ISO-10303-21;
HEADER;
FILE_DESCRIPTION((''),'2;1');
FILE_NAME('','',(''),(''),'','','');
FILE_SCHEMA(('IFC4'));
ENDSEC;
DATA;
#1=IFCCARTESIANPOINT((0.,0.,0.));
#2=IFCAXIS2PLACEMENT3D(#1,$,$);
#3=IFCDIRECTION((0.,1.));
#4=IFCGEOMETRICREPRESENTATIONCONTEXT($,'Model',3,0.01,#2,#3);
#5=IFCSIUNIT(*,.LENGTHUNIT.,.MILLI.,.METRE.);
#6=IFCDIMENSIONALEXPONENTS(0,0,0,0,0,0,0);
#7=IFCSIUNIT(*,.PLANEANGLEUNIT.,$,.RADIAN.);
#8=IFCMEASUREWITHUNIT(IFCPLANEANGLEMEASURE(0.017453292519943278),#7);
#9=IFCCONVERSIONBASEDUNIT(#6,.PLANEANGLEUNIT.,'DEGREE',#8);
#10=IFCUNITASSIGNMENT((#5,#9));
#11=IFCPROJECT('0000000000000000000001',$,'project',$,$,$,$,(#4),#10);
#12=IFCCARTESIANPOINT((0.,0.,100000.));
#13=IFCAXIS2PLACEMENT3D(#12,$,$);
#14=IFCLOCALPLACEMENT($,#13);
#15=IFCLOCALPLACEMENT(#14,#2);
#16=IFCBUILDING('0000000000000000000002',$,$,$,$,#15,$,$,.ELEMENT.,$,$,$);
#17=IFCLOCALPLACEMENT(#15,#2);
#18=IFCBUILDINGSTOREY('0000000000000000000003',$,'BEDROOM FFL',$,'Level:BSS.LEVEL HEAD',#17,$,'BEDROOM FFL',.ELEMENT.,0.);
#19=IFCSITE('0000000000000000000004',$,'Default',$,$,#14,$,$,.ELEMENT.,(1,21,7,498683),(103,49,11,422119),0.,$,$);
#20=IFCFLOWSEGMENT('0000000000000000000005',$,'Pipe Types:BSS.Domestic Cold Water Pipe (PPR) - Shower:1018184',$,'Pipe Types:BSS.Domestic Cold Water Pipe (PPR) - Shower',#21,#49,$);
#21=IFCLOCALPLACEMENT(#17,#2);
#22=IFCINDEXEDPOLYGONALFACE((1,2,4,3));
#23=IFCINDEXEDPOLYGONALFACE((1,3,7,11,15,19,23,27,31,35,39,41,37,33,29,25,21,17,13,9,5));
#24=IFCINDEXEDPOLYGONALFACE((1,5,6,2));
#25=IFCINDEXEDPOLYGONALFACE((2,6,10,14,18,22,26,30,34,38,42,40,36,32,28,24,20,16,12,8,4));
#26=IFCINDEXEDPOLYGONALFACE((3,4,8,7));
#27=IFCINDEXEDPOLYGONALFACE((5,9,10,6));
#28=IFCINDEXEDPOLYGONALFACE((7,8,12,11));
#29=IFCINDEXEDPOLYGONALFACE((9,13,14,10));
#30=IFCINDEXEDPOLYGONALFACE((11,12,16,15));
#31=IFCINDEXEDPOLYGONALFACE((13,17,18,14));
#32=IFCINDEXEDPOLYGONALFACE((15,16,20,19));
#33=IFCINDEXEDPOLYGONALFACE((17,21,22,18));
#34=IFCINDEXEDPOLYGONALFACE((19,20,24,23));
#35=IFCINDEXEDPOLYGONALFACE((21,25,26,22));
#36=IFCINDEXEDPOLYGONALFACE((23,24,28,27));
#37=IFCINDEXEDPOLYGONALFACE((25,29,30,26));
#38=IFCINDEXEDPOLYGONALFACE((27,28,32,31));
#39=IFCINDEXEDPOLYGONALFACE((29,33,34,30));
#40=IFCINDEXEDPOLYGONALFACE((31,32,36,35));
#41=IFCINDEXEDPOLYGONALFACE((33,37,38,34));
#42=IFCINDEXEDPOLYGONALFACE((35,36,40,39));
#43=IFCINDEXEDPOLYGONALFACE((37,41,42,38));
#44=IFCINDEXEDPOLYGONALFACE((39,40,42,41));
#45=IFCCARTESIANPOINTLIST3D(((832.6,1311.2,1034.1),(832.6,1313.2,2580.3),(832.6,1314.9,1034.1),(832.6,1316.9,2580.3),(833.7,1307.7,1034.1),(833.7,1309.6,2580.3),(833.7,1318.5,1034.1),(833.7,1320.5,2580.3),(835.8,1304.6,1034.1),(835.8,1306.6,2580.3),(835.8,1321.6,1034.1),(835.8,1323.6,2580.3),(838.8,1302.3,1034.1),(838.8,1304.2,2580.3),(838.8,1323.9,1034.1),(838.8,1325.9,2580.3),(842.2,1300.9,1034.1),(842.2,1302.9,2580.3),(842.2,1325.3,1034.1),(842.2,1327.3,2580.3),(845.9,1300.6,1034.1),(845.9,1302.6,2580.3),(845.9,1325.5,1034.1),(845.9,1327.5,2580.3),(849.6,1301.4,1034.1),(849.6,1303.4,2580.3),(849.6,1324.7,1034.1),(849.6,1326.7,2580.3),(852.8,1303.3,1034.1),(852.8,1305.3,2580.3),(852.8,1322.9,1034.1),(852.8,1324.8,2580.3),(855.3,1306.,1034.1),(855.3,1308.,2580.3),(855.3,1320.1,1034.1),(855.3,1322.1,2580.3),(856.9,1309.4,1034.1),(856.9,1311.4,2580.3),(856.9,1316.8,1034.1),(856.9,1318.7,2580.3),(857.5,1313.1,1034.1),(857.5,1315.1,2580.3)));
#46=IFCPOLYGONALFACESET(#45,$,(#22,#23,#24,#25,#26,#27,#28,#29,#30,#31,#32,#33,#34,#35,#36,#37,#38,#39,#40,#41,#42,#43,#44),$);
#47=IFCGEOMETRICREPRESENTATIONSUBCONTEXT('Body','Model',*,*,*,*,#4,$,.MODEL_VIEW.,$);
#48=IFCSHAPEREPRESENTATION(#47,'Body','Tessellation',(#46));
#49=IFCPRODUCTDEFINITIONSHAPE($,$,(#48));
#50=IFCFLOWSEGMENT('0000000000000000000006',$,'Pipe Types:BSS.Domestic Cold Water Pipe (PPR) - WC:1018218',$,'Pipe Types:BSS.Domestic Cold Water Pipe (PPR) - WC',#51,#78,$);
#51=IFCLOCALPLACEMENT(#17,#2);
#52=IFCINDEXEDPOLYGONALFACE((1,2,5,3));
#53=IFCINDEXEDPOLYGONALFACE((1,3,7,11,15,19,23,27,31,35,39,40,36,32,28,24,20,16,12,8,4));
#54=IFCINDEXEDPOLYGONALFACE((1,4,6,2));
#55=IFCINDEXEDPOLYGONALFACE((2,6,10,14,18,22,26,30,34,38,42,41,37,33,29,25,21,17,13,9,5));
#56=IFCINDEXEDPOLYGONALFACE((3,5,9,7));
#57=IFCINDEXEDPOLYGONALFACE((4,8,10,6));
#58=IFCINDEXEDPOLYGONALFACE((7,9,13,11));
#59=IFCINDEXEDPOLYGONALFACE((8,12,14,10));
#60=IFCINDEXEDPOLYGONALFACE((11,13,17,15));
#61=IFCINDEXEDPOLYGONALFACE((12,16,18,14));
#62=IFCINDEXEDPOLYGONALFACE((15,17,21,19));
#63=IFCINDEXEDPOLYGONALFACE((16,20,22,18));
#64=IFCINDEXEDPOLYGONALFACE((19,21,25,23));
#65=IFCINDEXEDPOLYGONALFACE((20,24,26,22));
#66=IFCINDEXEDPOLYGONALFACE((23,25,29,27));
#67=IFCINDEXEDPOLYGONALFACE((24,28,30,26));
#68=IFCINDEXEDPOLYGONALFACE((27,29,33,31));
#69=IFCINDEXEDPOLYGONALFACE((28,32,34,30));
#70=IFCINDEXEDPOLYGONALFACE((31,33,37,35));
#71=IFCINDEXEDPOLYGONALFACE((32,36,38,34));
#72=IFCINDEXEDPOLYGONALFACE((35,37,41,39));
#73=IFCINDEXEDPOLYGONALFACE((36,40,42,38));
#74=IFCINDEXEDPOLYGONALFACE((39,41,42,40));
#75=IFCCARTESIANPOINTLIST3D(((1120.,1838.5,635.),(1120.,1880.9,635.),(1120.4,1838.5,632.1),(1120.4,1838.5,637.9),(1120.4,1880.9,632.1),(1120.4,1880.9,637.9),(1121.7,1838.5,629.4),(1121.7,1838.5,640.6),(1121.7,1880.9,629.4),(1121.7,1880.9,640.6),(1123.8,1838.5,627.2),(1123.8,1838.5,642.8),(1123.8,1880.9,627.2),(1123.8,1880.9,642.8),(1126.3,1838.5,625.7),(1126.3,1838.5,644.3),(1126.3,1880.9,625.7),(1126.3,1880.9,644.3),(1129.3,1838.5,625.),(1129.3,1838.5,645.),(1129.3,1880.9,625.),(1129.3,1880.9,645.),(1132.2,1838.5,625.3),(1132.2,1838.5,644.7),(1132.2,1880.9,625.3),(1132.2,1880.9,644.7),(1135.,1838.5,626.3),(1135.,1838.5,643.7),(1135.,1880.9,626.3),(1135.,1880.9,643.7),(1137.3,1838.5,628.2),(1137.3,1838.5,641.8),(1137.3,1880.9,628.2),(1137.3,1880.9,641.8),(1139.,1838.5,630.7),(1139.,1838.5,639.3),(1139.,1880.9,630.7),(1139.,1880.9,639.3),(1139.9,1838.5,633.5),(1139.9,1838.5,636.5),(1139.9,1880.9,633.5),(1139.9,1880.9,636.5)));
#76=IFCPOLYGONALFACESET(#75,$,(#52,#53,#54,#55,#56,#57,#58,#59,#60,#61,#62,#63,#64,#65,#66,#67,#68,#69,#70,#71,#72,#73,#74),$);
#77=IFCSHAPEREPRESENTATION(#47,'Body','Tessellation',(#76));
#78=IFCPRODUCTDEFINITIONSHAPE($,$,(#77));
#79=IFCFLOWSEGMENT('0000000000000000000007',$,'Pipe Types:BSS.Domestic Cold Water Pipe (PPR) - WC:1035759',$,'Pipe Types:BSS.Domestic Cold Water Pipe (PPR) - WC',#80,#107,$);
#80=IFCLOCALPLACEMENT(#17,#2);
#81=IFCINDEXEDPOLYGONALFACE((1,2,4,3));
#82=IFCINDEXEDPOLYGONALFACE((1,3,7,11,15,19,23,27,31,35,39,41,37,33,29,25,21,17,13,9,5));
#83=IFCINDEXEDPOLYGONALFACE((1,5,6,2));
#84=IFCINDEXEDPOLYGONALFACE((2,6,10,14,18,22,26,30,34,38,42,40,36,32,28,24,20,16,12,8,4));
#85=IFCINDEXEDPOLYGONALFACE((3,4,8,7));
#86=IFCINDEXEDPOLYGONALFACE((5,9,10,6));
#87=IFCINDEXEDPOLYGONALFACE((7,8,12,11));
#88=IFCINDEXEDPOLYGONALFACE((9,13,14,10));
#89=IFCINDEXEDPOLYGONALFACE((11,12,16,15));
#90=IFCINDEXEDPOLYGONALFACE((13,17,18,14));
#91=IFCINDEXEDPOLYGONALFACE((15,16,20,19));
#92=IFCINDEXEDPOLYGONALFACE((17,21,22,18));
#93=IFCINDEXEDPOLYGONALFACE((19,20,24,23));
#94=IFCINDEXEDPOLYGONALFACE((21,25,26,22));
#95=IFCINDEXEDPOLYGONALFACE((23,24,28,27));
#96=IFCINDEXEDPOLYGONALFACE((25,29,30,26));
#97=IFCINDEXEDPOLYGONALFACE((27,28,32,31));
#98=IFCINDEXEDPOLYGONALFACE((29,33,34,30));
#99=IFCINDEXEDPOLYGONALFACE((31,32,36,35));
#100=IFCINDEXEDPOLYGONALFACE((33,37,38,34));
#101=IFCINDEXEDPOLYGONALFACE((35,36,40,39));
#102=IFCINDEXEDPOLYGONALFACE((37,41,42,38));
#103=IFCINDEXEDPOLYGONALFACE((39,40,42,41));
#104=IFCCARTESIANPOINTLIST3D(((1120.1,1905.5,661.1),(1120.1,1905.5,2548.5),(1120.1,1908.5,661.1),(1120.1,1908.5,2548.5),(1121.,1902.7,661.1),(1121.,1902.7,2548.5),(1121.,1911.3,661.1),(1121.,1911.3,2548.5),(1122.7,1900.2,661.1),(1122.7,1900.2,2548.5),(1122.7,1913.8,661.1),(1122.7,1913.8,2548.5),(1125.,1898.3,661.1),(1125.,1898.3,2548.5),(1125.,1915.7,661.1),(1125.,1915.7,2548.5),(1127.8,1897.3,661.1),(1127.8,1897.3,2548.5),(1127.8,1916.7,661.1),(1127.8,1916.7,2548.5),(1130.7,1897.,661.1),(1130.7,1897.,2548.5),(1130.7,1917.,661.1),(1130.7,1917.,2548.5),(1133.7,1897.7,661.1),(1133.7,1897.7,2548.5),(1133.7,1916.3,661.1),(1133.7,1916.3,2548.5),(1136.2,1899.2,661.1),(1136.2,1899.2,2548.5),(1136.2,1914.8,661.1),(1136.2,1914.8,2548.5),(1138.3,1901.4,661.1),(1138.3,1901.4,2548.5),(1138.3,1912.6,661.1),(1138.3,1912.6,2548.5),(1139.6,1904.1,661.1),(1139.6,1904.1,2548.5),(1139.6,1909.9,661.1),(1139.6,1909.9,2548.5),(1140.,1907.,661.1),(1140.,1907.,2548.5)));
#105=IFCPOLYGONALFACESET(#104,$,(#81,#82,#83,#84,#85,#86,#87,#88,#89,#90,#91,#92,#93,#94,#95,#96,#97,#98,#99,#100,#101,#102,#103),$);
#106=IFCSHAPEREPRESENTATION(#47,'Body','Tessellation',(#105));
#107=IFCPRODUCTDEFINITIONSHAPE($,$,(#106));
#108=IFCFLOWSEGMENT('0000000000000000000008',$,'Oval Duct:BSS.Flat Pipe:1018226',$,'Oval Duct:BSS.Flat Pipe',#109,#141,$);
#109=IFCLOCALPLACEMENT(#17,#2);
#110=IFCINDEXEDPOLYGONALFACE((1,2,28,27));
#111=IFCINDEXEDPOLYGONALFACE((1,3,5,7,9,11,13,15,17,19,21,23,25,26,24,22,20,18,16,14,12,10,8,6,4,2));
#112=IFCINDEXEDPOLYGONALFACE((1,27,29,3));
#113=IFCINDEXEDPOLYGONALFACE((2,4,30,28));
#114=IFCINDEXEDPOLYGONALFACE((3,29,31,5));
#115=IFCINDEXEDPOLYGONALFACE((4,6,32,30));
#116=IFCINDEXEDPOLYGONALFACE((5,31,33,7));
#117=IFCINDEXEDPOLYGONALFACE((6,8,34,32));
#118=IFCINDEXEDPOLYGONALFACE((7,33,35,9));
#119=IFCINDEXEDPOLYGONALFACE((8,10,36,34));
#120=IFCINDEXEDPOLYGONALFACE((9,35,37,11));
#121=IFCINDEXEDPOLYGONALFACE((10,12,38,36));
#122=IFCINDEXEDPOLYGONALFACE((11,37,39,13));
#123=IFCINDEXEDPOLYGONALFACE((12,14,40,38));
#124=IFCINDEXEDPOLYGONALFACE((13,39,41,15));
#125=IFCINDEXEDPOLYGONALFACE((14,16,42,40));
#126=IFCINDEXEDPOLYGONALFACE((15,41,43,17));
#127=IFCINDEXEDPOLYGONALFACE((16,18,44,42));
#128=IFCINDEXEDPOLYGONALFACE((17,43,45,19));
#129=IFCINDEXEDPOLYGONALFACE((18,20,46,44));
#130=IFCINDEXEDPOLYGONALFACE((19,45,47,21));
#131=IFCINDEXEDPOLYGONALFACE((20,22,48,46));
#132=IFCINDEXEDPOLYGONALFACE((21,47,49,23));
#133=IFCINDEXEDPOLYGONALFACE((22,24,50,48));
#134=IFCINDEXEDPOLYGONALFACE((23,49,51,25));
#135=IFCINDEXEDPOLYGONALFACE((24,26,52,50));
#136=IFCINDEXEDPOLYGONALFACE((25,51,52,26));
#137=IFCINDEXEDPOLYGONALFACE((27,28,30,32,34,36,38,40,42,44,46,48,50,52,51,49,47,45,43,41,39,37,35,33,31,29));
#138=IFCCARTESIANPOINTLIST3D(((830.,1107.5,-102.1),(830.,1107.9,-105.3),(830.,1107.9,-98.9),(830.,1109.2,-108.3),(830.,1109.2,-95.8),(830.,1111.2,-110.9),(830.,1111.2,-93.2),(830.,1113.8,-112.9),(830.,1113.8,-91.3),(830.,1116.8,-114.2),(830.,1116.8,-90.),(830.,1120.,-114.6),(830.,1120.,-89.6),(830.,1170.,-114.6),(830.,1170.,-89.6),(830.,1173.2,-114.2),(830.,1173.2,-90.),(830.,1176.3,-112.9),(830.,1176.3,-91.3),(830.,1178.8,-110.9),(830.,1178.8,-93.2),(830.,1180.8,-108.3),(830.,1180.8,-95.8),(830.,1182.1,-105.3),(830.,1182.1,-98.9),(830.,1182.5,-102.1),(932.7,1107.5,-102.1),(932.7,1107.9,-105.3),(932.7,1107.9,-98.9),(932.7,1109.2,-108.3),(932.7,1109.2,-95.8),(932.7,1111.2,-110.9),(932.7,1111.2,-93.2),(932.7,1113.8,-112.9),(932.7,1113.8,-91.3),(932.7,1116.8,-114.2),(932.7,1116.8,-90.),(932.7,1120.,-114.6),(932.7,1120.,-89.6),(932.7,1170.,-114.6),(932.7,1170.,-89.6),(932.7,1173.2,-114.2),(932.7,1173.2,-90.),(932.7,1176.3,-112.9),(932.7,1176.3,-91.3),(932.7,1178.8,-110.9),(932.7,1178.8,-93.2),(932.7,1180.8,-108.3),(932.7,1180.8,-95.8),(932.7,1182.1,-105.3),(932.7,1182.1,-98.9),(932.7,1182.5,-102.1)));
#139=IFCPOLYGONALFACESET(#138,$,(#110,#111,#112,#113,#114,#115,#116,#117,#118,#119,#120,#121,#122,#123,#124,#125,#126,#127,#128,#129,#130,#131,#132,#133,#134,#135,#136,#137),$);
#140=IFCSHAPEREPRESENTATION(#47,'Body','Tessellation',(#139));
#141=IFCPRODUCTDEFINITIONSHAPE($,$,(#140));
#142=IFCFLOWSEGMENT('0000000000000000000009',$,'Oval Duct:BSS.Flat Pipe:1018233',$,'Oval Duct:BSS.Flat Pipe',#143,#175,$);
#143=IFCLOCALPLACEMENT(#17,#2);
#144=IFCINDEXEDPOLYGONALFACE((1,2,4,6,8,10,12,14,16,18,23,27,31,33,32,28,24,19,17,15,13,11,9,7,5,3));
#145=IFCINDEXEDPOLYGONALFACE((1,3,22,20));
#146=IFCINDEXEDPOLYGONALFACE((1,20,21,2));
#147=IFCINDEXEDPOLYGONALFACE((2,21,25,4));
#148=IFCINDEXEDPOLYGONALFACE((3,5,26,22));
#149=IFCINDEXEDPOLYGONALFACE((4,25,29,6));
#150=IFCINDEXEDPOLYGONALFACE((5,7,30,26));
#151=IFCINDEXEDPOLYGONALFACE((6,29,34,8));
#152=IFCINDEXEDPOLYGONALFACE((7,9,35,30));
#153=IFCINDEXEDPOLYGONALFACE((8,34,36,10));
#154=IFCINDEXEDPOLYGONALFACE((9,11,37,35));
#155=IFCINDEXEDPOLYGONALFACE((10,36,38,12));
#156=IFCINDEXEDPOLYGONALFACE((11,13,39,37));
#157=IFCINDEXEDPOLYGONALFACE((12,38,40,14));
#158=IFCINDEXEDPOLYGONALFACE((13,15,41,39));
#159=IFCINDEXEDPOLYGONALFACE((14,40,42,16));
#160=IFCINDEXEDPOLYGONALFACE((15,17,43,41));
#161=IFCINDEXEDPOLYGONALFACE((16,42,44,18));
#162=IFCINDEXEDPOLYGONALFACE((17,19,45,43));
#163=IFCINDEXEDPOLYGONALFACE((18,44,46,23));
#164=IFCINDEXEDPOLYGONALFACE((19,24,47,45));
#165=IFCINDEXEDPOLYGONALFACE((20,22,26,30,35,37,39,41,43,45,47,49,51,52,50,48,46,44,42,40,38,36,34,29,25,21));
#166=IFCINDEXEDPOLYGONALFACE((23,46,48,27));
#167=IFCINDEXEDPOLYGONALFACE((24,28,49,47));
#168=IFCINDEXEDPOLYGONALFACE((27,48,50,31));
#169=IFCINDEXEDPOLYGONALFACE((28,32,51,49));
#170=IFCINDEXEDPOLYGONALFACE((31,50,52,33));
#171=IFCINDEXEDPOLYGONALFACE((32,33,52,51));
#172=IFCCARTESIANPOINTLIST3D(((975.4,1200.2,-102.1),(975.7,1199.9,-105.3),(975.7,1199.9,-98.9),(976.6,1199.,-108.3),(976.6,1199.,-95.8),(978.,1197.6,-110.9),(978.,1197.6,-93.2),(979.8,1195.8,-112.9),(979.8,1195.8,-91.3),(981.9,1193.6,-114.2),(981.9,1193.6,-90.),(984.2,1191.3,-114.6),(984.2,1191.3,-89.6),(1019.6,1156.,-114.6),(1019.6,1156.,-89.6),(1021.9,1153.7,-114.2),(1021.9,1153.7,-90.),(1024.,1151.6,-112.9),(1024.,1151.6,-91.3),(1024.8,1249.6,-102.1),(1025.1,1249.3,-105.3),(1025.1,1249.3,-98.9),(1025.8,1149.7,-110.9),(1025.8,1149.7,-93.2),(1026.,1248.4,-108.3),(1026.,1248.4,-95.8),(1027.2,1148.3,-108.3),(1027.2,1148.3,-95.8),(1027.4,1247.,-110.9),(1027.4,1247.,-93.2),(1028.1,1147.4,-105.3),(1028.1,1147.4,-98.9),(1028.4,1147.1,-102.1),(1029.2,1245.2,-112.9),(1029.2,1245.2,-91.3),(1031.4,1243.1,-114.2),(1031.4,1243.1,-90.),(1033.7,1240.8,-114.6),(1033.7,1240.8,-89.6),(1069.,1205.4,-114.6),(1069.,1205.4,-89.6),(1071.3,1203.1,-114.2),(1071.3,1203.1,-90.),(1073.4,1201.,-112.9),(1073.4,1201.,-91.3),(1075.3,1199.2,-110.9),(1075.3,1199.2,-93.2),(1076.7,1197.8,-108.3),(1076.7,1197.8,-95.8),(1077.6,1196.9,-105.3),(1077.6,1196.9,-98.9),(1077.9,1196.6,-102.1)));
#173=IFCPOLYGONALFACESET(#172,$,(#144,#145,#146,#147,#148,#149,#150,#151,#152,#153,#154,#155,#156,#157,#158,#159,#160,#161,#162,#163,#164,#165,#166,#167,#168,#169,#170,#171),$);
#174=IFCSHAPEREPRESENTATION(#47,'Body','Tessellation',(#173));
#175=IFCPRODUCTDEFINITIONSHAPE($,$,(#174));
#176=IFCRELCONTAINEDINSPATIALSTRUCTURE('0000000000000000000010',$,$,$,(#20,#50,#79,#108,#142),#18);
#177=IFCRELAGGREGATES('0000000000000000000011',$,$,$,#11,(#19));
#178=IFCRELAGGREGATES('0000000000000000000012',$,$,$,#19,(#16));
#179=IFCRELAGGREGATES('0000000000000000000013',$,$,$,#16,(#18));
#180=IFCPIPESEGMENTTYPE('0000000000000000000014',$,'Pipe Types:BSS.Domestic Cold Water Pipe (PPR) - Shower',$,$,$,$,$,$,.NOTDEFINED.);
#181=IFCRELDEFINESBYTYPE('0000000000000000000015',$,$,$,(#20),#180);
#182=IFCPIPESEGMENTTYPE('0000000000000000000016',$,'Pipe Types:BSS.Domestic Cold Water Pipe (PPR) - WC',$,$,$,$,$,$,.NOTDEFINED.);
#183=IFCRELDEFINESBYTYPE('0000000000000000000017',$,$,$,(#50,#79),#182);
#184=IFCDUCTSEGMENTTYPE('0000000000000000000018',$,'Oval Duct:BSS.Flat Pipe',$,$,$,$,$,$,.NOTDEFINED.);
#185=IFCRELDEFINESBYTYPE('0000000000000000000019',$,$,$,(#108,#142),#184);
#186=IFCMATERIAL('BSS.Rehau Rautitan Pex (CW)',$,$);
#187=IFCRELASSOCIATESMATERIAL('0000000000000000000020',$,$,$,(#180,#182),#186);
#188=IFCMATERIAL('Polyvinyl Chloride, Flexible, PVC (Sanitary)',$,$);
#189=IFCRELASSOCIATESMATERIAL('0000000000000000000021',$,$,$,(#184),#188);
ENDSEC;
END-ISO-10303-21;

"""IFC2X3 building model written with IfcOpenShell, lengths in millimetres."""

from ifc_helpers import new_model, entity, si_unit, converted_unit, direction, frame, frame_2d, origin, origin_2d_with_axis, place, context, subcontext, project, spatial, polyline, circle_curve, parameter, trimmed, segment, composite_curve, circle, outline, extrude, material, type_object, element, save


model = new_model("IFC2X3")

# Units and contexts
model_context = context("Model", 3, precision=0.01, world=origin(), true_north=direction((0.0, 1.0)))
body_context = subcontext(model_context, "Body", "Model", "MODEL_VIEW")
ifc_project = project(units=[si_unit("LENGTHUNIT", "METRE", prefix="MILLI"), converted_unit("PLANEANGLEUNIT", "DEGREE", entity("IfcPlaneAngleMeasure", 0.017453292519943278), si_unit("PLANEANGLEUNIT", "RADIAN"), dimensions=[0, 0, 0, 0, 0, 0, 0])], contexts=[model_context])

# Site, building, storey
site_placement = place(None, frame((0.0, 0.0, 100000.0)))
site = spatial("IfcSite", under=ifc_project, at=site_placement, Name="Default", CompositionType="ELEMENT", RefLatitude=(1, 21, 7, 498683), RefLongitude=(103, 49, 11, 422119), RefElevation=0.0)
building_placement = place(site_placement, origin())
building = spatial("IfcBuilding", under=site, at=building_placement, CompositionType="ELEMENT")
storey_placement = place(building_placement, origin())
storey = spatial("IfcBuildingStorey", under=building, at=storey_placement, Name="BEDROOM FFL", ObjectType="Level:BSS.LEVEL HEAD", LongName="BEDROOM FFL", CompositionType="ELEMENT", Elevation=0.0)

# Flow segments
ifc_material_1 = material(Name="Polyvinyl Chloride, Flexible, PVC (Sanitary)")
ifc_material_2 = material(Name="BSS.Rehau Rautitan Pex (CW)")
pipe_segment_type_1 = type_object("IfcPipeSegmentType", Name="Pipe Types:BSS.Domestic Cold Water Pipe (PPR) - Shower", PredefinedType="NOTDEFINED", material=ifc_material_2)
flow_segment_1_placement = place(storey_placement, origin())
element("IfcFlowSegment", 1, at=flow_segment_1_placement, inside=storey, type_object=pipe_segment_type_1, Name="Pipe Types:BSS.Domestic Cold Water Pipe (PPR) - Shower:1018184", ObjectType="Pipe Types:BSS.Domestic Cold Water Pipe (PPR) - Shower", context=body_context, shape_type="SweptSolid", body=[
    extrude(circle(Radius=12.5, at=frame_2d((0.0, 0.0), x_axis=(1.0, 0.0))), frame((845.0, 1313.1, 1034.1), z_axis=(0.000001, 0.001284, 0.999999), x_axis=(1.0, 0.0, -0.000001)), (0.0, 0.0, 1.0), 1546.2),
])
pipe_segment_type_2 = type_object("IfcPipeSegmentType", Name="Pipe Types:BSS.Domestic Cold Water Pipe (PPR) - WC", PredefinedType="NOTDEFINED", material=ifc_material_2)
flow_segment_2_placement = place(storey_placement, origin())
element("IfcFlowSegment", 2, at=flow_segment_2_placement, inside=storey, type_object=pipe_segment_type_2, Name="Pipe Types:BSS.Domestic Cold Water Pipe (PPR) - WC:1018218", ObjectType="Pipe Types:BSS.Domestic Cold Water Pipe (PPR) - WC", context=body_context, shape_type="SweptSolid", body=[
    extrude(circle(Radius=10.0, at=origin_2d_with_axis()), frame((1130.0, 1838.5, 635.0), z_axis=(0.0, 1.0, 0.0), x_axis=(-1.0, 0.0, 0.0)), (0.0, 0.0, 1.0), 42.4),
])
flow_segment_3_placement = place(storey_placement, origin())
element("IfcFlowSegment", 3, at=flow_segment_3_placement, inside=storey, type_object=pipe_segment_type_2, Name="Pipe Types:BSS.Domestic Cold Water Pipe (PPR) - WC:1035759", ObjectType="Pipe Types:BSS.Domestic Cold Water Pipe (PPR) - WC", context=body_context, shape_type="SweptSolid", body=[
    extrude(circle(Radius=10.0, at=frame_2d((0.0, 0.0), x_axis=(1.0, 0.0))), frame((1130.0, 1907.0, 661.1)), (0.0, 0.0, 1.0), 1887.4),
])
duct_segment_type = type_object("IfcDuctSegmentType", Name="Oval Duct:BSS.Flat Pipe", PredefinedType="NOTDEFINED", material=ifc_material_1)
flow_segment_4_placement = place(storey_placement, origin())
element("IfcFlowSegment", 4, at=flow_segment_4_placement, inside=storey, type_object=duct_segment_type, Name="Oval Duct:BSS.Flat Pipe:1018226", ObjectType="Oval Duct:BSS.Flat Pipe", context=body_context, shape_type="SweptSolid", body=[
    extrude(outline(composite_curve([segment(polyline([(-25.0, -12.5), (25.0, -12.5)]), True, "CONTINUOUS"), segment(trimmed(circle_curve(frame_2d((25.0, 0.0), x_axis=(-1.0, 0.0)), 12.5), [parameter(90.0)], [parameter(180.0)], True, "PARAMETER"), True, "CONTINUOUS"), segment(trimmed(circle_curve(frame_2d((25.0, 0.0), x_axis=(-1.0, 0.0)), 12.5), [parameter(180.0)], [parameter(270.0)], True, "PARAMETER"), True, "CONTINUOUS"), segment(polyline([(25.0, 12.5), (-25.0, 12.5)]), True, "CONTINUOUS"), segment(trimmed(circle_curve(frame_2d((-25.0, 0.0), x_axis=(-1.0, 0.0)), 12.5), [parameter(270.0)], [parameter(0.0)], True, "PARAMETER"), True, "CONTINUOUS"), segment(trimmed(circle_curve(frame_2d((-25.0, 0.0), x_axis=(-1.0, 0.0)), 12.5), [parameter(0.0)], [parameter(90.0)], True, "PARAMETER"), True, "CONTINUOUS")], self_intersect=False)), frame((830.0, 1145.0, -102.1), z_axis=(1.0, 0.0, 0.0), x_axis=(0.0, -1.0, 0.0)), (0.0, 0.0, 1.0), 102.7),
])
flow_segment_5_placement = place(storey_placement, origin())
element("IfcFlowSegment", 5, at=flow_segment_5_placement, inside=storey, type_object=duct_segment_type, Name="Oval Duct:BSS.Flat Pipe:1018233", ObjectType="Oval Duct:BSS.Flat Pipe", context=body_context, shape_type="SweptSolid", body=[
    extrude(outline(composite_curve([segment(polyline([(-25.0, -12.5), (25.0, -12.5)]), True, "CONTINUOUS"), segment(trimmed(circle_curve(frame_2d((25.0, 0.0), x_axis=(-1.0, 0.0)), 12.5), [parameter(90.0)], [parameter(180.0)], True, "PARAMETER"), True, "CONTINUOUS"), segment(trimmed(circle_curve(frame_2d((25.0, 0.0), x_axis=(-1.0, 0.0)), 12.5), [parameter(180.0)], [parameter(270.0)], True, "PARAMETER"), True, "CONTINUOUS"), segment(polyline([(25.0, 12.5), (-25.0, 12.5)]), True, "CONTINUOUS"), segment(trimmed(circle_curve(frame_2d((-25.0, 0.0), x_axis=(-1.0, 0.0)), 12.5), [parameter(270.0)], [parameter(0.0)], True, "PARAMETER"), True, "CONTINUOUS"), segment(trimmed(circle_curve(frame_2d((-25.0, 0.0), x_axis=(-1.0, 0.0)), 12.5), [parameter(0.0)], [parameter(90.0)], True, "PARAMETER"), True, "CONTINUOUS")], self_intersect=False)), frame((1001.9, 1173.7, -102.1), z_axis=(0.707108, 0.707105, 0.0), x_axis=(0.707105, -0.707108, 0.0)), (0.0, 0.0, 1.0), 69.9),
])

save(model, "model.ifc")
